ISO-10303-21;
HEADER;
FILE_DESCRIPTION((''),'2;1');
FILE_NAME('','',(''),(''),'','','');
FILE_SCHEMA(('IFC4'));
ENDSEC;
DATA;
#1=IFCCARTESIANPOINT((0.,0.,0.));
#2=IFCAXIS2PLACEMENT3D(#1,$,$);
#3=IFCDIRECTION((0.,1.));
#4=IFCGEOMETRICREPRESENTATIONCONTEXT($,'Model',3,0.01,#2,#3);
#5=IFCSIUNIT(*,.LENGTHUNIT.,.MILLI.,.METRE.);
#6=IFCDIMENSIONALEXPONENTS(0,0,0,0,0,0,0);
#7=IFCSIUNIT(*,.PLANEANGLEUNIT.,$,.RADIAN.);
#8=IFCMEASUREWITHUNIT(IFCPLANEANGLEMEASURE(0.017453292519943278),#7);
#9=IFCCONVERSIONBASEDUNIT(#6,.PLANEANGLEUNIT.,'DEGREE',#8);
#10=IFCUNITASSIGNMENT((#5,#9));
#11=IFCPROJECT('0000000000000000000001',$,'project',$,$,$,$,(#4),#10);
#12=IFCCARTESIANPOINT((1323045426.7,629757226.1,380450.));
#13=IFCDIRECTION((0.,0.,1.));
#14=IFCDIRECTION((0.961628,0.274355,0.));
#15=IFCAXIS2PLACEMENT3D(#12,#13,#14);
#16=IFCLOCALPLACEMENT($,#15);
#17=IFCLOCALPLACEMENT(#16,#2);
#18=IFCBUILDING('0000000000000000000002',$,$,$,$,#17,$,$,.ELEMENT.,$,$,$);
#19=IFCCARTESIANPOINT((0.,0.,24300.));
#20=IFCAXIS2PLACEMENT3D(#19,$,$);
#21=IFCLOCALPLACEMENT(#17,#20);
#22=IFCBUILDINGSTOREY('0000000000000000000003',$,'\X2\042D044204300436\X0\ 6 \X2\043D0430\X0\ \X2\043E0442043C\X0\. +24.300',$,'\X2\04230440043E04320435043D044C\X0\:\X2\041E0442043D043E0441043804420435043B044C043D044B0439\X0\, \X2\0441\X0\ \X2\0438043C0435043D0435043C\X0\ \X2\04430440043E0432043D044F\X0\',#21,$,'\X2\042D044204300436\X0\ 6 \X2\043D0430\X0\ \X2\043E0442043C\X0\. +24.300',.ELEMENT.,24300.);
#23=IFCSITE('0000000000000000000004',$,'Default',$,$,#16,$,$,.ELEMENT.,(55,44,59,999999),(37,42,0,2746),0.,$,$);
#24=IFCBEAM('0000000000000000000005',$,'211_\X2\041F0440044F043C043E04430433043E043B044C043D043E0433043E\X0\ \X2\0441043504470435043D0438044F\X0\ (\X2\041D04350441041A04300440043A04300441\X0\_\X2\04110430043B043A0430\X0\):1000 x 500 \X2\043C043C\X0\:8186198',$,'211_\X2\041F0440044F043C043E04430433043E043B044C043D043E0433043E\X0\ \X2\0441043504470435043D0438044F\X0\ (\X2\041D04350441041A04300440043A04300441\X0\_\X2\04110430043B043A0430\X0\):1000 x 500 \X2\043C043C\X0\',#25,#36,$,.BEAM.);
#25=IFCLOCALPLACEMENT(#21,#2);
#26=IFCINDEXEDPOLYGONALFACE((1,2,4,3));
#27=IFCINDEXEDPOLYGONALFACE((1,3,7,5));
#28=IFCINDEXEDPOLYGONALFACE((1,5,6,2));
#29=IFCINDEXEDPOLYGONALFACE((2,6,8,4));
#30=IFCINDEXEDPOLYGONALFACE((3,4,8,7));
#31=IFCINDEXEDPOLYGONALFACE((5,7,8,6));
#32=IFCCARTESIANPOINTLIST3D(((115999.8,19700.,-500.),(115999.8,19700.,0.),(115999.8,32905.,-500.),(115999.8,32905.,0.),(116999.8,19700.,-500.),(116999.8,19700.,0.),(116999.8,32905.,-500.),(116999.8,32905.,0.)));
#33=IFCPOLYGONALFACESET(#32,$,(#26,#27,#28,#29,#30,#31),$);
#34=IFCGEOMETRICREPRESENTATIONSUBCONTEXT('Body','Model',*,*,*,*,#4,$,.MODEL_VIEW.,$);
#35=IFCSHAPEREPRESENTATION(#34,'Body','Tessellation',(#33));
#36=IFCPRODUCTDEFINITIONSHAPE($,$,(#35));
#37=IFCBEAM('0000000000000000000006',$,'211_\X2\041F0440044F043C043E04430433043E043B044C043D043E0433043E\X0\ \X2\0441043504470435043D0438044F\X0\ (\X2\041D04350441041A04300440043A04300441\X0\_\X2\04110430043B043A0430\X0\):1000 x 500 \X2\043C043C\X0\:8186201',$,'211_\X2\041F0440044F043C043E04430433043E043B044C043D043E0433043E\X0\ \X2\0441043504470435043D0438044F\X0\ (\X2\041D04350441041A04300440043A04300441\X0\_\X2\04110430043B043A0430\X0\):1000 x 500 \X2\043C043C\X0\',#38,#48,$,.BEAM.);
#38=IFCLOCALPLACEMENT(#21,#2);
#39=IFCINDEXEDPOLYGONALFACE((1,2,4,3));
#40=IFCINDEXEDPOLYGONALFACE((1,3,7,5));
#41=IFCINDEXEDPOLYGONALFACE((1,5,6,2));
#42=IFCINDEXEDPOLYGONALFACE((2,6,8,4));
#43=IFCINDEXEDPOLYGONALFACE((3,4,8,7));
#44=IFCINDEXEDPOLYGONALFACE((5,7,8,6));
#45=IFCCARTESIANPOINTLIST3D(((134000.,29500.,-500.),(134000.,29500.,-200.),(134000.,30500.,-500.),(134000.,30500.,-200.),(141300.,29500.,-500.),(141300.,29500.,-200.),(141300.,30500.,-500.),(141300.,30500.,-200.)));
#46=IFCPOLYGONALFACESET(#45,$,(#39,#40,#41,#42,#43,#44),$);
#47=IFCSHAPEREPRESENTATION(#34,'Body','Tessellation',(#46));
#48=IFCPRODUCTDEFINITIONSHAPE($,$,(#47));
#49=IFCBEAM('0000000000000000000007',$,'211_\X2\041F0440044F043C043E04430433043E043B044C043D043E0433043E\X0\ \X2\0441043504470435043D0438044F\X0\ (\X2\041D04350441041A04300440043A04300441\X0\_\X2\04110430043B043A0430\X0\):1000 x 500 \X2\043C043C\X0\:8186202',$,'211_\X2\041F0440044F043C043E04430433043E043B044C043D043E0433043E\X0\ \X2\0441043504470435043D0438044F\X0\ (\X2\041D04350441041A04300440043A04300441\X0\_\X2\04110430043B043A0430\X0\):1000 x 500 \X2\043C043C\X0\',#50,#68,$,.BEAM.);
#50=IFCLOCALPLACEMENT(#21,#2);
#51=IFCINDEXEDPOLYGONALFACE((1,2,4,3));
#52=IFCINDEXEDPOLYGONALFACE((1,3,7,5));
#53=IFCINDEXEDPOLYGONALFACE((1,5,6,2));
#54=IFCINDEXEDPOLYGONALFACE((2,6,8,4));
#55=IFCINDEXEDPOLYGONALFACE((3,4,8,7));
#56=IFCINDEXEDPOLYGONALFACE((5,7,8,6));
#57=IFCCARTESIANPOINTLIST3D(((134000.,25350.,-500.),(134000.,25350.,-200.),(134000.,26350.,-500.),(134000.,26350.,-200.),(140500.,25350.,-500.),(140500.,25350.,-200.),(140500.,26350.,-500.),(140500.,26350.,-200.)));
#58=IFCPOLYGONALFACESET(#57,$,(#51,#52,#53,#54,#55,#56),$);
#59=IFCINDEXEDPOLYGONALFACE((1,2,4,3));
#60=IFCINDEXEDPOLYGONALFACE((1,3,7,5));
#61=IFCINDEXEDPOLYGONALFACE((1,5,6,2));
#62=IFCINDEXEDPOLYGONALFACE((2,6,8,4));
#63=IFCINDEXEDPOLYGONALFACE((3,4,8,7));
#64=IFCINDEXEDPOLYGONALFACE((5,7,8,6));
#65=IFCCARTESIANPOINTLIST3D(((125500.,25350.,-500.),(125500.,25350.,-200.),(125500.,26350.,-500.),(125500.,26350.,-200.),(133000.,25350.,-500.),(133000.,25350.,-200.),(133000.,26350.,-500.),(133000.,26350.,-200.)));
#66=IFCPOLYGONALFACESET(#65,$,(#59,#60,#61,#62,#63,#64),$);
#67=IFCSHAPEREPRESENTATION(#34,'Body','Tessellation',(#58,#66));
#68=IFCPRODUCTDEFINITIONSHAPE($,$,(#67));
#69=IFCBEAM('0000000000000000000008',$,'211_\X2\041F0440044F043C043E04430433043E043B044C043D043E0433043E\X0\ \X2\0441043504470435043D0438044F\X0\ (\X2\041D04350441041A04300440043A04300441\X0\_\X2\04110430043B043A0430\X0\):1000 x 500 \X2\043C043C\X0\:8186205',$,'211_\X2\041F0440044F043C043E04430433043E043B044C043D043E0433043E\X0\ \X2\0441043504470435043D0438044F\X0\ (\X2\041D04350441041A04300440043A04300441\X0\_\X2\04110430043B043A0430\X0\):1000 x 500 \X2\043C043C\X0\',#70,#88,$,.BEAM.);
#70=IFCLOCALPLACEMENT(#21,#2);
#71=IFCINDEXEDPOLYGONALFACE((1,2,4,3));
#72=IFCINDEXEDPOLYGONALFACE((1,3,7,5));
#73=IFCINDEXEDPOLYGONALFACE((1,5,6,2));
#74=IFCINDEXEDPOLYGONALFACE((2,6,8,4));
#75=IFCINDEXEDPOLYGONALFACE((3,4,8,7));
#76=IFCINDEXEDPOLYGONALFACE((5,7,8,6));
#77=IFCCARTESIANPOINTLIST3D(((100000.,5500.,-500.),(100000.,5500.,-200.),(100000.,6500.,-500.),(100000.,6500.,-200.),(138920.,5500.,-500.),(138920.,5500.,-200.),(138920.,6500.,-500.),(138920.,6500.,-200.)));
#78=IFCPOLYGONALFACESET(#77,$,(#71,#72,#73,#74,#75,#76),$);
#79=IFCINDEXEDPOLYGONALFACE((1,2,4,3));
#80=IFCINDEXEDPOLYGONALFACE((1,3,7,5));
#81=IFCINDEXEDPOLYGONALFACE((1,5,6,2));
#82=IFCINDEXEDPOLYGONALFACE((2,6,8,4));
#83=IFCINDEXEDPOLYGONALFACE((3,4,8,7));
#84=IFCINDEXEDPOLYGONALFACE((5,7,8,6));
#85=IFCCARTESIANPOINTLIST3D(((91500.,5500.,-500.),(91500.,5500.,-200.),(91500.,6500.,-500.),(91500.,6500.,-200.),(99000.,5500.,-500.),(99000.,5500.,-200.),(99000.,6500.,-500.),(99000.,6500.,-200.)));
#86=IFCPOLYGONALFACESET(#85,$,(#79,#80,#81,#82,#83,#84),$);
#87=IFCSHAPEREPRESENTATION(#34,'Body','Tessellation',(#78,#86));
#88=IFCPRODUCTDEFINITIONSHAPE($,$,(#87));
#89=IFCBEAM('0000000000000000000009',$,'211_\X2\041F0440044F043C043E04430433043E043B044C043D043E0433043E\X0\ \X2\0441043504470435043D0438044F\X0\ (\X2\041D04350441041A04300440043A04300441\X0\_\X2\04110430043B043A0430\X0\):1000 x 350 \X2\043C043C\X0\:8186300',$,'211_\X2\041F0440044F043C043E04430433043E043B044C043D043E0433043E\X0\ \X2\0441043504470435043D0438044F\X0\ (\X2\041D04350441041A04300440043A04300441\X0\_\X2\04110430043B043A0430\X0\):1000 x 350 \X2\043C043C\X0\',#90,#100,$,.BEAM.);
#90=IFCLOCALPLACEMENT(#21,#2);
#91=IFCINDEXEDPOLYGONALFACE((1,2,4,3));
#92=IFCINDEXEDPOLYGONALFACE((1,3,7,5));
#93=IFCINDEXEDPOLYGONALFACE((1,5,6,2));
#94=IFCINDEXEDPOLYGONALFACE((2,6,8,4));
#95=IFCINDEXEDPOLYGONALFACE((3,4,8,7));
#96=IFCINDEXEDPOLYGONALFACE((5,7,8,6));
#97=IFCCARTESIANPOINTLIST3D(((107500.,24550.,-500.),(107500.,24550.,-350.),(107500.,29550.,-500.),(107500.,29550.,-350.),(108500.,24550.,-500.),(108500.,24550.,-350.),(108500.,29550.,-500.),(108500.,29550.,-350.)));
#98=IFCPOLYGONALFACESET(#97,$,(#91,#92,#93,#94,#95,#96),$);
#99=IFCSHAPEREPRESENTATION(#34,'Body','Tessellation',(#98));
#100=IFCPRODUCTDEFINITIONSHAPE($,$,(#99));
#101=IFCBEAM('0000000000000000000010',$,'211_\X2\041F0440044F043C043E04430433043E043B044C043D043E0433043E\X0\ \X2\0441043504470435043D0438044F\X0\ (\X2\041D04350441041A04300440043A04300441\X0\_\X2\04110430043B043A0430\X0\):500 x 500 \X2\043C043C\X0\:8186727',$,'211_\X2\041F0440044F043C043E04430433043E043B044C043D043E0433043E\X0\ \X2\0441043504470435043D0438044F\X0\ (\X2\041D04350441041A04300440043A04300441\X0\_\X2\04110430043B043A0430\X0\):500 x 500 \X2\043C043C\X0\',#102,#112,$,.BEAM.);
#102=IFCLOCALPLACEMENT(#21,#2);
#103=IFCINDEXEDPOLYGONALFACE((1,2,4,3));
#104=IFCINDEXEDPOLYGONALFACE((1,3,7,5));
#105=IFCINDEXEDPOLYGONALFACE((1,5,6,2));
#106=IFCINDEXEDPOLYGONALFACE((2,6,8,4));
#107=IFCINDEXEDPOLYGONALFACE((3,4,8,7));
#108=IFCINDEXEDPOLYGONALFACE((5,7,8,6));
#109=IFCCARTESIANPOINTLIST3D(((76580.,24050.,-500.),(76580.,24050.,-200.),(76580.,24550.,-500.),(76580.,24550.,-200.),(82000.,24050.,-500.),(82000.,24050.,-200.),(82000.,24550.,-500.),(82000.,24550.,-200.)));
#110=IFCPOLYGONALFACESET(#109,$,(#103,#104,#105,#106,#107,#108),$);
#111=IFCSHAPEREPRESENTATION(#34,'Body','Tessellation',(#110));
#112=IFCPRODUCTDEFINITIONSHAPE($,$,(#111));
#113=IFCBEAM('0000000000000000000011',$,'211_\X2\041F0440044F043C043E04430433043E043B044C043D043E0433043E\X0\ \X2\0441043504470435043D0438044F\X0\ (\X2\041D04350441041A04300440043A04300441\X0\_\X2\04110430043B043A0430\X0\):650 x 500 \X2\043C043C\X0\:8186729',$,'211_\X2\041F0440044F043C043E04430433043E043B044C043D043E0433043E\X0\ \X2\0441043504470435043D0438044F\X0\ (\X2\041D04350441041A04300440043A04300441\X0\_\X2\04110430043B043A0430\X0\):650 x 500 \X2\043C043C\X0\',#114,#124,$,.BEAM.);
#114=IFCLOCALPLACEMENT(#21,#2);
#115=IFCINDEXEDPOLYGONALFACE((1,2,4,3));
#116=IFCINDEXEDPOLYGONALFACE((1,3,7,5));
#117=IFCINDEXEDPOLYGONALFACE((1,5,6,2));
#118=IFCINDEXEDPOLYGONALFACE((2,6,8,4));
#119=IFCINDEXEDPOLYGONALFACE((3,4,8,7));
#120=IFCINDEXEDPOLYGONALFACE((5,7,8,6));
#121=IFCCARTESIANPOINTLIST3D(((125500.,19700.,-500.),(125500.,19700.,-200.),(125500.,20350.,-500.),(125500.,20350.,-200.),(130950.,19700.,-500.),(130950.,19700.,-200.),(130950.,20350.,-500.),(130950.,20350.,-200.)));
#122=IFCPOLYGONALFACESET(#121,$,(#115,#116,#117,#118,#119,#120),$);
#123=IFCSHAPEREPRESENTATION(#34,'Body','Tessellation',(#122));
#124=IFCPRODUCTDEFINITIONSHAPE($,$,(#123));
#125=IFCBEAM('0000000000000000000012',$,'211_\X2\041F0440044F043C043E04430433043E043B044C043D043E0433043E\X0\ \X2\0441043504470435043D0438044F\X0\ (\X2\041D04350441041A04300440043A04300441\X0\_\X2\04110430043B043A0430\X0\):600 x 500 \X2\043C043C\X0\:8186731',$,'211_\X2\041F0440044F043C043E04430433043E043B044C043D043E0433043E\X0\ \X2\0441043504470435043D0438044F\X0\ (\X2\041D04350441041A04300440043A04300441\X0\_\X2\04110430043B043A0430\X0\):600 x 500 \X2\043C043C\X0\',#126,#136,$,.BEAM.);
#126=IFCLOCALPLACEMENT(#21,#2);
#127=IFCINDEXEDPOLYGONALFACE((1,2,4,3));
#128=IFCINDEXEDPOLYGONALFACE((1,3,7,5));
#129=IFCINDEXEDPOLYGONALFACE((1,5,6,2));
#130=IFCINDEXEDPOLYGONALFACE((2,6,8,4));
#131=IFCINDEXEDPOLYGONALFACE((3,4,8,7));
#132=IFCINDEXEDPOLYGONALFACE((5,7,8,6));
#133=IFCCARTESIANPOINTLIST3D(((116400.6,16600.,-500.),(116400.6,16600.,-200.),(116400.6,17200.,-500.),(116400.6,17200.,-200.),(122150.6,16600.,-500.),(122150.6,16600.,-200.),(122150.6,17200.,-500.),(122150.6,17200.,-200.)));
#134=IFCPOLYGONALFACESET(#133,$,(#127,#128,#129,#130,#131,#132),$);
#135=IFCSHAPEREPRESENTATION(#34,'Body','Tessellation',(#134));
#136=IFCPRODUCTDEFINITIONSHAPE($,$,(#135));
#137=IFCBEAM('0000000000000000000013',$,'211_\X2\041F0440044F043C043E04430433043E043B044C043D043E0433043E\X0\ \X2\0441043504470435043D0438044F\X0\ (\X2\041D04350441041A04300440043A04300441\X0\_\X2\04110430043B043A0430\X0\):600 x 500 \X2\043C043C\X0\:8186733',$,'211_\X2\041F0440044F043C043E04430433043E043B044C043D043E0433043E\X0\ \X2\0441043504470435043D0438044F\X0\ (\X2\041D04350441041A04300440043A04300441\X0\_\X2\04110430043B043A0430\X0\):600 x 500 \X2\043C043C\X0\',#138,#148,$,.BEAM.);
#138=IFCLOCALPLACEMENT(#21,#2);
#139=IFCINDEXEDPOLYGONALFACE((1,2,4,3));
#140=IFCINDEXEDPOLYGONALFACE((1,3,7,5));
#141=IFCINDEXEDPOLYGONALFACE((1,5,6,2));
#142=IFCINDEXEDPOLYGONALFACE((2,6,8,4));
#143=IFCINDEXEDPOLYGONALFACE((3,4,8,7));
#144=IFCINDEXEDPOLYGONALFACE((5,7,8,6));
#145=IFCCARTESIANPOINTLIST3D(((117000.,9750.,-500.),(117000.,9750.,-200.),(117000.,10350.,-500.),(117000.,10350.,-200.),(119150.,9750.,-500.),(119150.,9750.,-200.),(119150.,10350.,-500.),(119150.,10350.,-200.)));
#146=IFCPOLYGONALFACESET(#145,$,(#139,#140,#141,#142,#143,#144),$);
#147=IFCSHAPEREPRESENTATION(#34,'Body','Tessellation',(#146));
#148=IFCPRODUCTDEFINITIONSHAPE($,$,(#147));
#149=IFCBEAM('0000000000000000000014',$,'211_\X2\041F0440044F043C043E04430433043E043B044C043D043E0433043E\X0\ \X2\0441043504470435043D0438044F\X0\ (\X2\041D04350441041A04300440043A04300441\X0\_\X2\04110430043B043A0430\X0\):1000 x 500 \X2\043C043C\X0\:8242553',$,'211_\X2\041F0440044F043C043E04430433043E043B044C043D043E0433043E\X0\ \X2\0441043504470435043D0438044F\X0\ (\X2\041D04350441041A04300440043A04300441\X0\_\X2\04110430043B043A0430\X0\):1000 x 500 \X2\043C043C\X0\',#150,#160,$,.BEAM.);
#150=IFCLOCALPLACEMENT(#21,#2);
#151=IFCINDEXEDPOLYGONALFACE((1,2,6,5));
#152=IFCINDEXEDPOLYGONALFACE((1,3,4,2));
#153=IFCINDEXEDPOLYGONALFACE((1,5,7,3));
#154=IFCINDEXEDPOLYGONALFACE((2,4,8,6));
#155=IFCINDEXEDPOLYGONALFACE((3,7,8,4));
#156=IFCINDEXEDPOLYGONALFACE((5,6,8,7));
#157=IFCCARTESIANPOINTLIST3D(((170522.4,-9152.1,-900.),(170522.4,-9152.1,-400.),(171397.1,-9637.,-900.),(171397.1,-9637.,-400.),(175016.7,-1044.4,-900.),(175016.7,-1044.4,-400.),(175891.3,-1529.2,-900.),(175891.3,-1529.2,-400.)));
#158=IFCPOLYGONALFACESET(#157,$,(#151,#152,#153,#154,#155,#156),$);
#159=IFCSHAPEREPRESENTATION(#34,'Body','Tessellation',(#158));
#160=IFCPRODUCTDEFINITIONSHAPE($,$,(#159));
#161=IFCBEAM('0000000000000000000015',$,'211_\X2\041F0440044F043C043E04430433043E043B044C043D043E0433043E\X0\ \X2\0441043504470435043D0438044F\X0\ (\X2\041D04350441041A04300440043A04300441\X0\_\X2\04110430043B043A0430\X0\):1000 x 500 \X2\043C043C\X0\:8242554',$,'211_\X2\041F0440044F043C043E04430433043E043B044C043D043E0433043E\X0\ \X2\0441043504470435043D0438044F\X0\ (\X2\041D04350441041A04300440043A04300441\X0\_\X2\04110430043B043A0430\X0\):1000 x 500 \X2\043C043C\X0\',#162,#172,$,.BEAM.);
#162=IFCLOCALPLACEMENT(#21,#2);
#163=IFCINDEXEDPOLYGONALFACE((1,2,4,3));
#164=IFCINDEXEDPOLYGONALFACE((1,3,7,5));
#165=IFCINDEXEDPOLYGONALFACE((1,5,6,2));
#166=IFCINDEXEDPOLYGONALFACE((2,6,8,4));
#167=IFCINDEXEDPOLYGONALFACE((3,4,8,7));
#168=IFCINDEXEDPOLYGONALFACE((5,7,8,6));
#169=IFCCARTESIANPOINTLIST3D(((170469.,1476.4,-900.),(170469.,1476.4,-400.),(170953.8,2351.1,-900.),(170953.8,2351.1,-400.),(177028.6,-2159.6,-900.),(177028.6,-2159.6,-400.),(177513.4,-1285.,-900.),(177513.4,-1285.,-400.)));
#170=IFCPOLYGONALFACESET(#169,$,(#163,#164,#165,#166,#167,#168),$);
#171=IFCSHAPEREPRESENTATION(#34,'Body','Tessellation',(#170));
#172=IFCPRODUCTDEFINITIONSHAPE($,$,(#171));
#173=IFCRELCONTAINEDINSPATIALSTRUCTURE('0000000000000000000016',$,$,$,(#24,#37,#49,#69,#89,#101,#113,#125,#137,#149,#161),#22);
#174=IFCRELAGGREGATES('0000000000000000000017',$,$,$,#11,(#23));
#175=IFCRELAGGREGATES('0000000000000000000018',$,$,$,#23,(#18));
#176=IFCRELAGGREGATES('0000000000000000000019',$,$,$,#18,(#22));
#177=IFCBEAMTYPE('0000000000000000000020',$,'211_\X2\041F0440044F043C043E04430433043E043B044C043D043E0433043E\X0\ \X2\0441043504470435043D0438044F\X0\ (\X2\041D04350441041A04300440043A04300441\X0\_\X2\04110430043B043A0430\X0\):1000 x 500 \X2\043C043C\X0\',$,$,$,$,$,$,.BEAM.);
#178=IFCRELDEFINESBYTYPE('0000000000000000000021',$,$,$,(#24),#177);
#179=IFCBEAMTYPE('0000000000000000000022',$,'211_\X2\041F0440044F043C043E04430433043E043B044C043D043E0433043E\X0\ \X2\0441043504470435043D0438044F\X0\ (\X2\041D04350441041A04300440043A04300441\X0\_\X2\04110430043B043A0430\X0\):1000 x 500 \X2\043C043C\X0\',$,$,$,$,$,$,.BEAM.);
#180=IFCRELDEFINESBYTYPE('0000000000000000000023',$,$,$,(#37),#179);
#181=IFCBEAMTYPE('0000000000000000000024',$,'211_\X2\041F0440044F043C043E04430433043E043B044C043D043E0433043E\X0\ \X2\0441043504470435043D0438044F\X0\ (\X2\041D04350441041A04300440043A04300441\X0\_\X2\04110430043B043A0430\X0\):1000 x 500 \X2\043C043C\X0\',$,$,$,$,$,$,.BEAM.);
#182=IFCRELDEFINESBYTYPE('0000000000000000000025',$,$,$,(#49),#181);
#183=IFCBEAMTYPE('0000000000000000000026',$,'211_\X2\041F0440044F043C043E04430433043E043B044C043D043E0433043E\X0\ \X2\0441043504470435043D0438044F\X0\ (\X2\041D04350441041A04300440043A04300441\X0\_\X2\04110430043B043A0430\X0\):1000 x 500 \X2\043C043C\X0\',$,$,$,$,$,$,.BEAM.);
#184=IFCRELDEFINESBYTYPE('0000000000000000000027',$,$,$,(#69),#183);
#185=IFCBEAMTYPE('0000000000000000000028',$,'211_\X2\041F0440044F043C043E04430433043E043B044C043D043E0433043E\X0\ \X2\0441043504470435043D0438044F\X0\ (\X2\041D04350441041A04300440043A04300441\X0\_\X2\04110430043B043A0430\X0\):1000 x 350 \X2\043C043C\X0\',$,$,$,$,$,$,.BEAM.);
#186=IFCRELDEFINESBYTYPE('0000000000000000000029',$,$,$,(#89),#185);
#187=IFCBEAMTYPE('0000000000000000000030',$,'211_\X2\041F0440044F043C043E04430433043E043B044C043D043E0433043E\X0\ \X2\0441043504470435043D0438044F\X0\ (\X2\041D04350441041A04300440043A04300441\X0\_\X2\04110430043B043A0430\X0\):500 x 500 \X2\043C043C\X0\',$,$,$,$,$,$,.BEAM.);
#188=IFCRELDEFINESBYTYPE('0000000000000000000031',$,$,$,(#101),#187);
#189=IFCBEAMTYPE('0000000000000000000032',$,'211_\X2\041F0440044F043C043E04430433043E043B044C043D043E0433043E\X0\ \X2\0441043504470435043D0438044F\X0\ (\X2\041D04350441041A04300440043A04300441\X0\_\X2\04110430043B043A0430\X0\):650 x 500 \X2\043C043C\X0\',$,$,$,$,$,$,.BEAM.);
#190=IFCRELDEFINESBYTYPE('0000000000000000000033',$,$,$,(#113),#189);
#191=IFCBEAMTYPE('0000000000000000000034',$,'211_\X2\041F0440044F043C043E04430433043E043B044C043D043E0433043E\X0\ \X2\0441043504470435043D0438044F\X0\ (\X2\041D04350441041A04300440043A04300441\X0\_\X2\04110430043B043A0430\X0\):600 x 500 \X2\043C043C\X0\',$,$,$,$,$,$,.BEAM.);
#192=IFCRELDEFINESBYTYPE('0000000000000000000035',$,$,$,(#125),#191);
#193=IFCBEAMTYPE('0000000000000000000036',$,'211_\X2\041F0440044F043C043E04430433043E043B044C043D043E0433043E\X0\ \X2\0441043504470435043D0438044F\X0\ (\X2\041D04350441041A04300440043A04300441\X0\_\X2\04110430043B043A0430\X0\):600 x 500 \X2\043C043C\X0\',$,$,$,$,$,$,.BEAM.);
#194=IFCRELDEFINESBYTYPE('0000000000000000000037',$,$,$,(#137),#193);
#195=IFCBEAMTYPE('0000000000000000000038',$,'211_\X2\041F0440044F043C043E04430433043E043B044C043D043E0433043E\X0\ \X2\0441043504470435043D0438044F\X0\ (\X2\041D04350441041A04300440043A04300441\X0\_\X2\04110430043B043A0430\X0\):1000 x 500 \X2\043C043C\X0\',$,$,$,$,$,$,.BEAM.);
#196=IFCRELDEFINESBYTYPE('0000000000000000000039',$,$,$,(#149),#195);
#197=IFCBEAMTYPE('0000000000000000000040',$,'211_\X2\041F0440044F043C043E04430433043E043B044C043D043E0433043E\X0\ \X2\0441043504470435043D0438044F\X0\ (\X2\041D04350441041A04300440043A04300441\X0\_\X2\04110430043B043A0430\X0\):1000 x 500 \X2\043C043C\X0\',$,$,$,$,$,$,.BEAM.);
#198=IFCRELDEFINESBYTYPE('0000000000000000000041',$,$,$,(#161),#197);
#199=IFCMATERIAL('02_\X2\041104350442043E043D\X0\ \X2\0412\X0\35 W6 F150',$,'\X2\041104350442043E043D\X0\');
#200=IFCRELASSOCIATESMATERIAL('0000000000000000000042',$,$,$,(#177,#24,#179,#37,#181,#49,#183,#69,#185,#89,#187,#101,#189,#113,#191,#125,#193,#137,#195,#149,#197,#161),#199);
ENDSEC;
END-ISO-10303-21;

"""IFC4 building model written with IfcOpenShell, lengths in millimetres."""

from ifc_helpers import new_model, entity, si_unit, converted_unit, direction, frame, origin, place, context, subcontext, project, spatial, indexed_curve, outline, extrude, source, transform, mapped, material, type_object, type_shapes, element, save


model = new_model("IFC4")

# Units and contexts
model_context = context("Model", 3, precision=0.01, world=origin(), true_north=direction((0.0, 1.0)))
body_context = subcontext(model_context, "Body", "Model", "MODEL_VIEW")
ifc_project = project(units=[si_unit("LENGTHUNIT", "METRE", prefix="MILLI"), converted_unit("PLANEANGLEUNIT", "DEGREE", entity("IfcPlaneAngleMeasure", 0.017453292519943278), si_unit("PLANEANGLEUNIT", "RADIAN"), dimensions=[0, 0, 0, 0, 0, 0, 0])], contexts=[model_context])

# Site, building, storey
site_placement = place(None, frame((1323045426.7, 629757226.1, 380450.0), z_axis=(0.0, 0.0, 1.0), x_axis=(0.961628, 0.274355, 0.0)))
site = spatial("IfcSite", under=ifc_project, at=site_placement, Name="Default", CompositionType="ELEMENT", RefLatitude=(55, 44, 59, 999999), RefLongitude=(37, 42, 0, 2746), RefElevation=0.0)
building_placement = place(site_placement, origin())
building = spatial("IfcBuilding", under=site, at=building_placement, CompositionType="ELEMENT")
storey_placement = place(building_placement, frame((0.0, 0.0, 24300.0)))
storey = spatial("IfcBuildingStorey", under=building, at=storey_placement, Name="Этаж 6 на отм. +24.300", ObjectType="Уровень:Относительный, с именем уровня", LongName="Этаж 6 на отм. +24.300", CompositionType="ELEMENT", Elevation=24300.0)

# Beams
ifc_material_1 = material(Name="02_Бетон В35 W6 F150", Category="Бетон")
beam_type_1 = type_object("IfcBeamType", Name="211_Прямоугольного сечения (НесКаркас_Балка):1000 x 500 мм", PredefinedType="BEAM", material=ifc_material_1)
shared_shape_1 = source(origin(), body_context, "Body", "SweptSolid", [
    extrude(outline(indexed_curve([(-500.0, -250.0), (500.0, -250.0), (500.0, 250.0), (-500.0, 250.0), (-500.0, -250.0)], self_intersect=False)), frame((116499.8, 32905.0, 24050.0), z_axis=(0.0, -1.0, 0.0), x_axis=(-1.0, 0.0, 0.0)), (0.0, 0.0, 1.0), 13205.0),
])
type_shapes(beam_type_1, [shared_shape_1])
beam_1_placement = place(storey_placement, frame((0.0, 0.0, -24300.0)))
element("IfcBeam", 1, at=beam_1_placement, inside=storey, type_object=beam_type_1, material=ifc_material_1, Name="211_Прямоугольного сечения (НесКаркас_Балка):1000 x 500 мм:8186198", ObjectType="211_Прямоугольного сечения (НесКаркас_Балка):1000 x 500 мм", PredefinedType="BEAM", context=body_context, shape_type="MappedRepresentation", body=[
    mapped(shared_shape_1, transform((0.0, 0.0, 0.0), scale=1.0)),
])
beam_type_2 = type_object("IfcBeamType", Name="211_Прямоугольного сечения (НесКаркас_Балка):1000 x 500 мм", PredefinedType="BEAM", material=ifc_material_1)
shared_shape_2 = source(origin(), body_context, "Body", "SweptSolid", [
    extrude(outline(indexed_curve([(-150.0, -500.0), (150.0, -500.0), (150.0, 500.0), (-150.0, 500.0), (-150.0, -500.0)], self_intersect=False)), frame((134000.0, 30000.0, 23950.0), z_axis=(1.0, 0.0, 0.0), x_axis=(0.0, 0.0, -1.0)), (0.0, 0.0, 1.0), 7300.0),
])
type_shapes(beam_type_2, [shared_shape_2])
beam_2_placement = place(storey_placement, frame((0.0, 0.0, -24300.0)))
element("IfcBeam", 2, at=beam_2_placement, inside=storey, type_object=beam_type_2, material=ifc_material_1, Name="211_Прямоугольного сечения (НесКаркас_Балка):1000 x 500 мм:8186201", ObjectType="211_Прямоугольного сечения (НесКаркас_Балка):1000 x 500 мм", PredefinedType="BEAM", context=body_context, shape_type="MappedRepresentation", body=[
    mapped(shared_shape_2, transform((0.0, 0.0, 0.0), scale=1.0)),
])
beam_type_3 = type_object("IfcBeamType", Name="211_Прямоугольного сечения (НесКаркас_Балка):1000 x 500 мм", PredefinedType="BEAM", material=ifc_material_1)
shared_shape_3 = source(origin(), body_context, "Body", "SweptSolid", [
    extrude(outline(indexed_curve([(-150.0, -500.0), (150.0, -500.0), (150.0, 500.0), (-150.0, 500.0), (-150.0, -500.0)], self_intersect=False)), frame((134000.0, 25850.0, 23950.0), z_axis=(1.0, 0.0, 0.0), x_axis=(0.0, 0.0, -1.0)), (0.0, 0.0, 1.0), 6500.0),
    extrude(outline(indexed_curve([(-150.0, -500.0), (150.0, -500.0), (150.0, 500.0), (-150.0, 500.0), (-150.0, -500.0)], self_intersect=False)), frame((125500.0, 25850.0, 23950.0), z_axis=(1.0, 0.0, 0.0), x_axis=(0.0, 0.0, -1.0)), (0.0, 0.0, 1.0), 7500.0),
])
type_shapes(beam_type_3, [shared_shape_3])
beam_3_placement = place(storey_placement, frame((0.0, 0.0, -24300.0)))
element("IfcBeam", 3, at=beam_3_placement, inside=storey, type_object=beam_type_3, material=ifc_material_1, Name="211_Прямоугольного сечения (НесКаркас_Балка):1000 x 500 мм:8186202", ObjectType="211_Прямоугольного сечения (НесКаркас_Балка):1000 x 500 мм", PredefinedType="BEAM", context=body_context, shape_type="MappedRepresentation", body=[
    mapped(shared_shape_3, transform((0.0, 0.0, 0.0), scale=1.0)),
])
beam_type_4 = type_object("IfcBeamType", Name="211_Прямоугольного сечения (НесКаркас_Балка):1000 x 500 мм", PredefinedType="BEAM", material=ifc_material_1)
shared_shape_4 = source(origin(), body_context, "Body", "SweptSolid", [
    extrude(outline(indexed_curve([(-150.0, -500.0), (150.0, -500.0), (150.0, 500.0), (-150.0, 500.0), (-150.0, -500.0)], self_intersect=False)), frame((138920.0, 6000.0, 23950.0), z_axis=(-1.0, 0.0, 0.0), x_axis=(0.0, 0.0, -1.0)), (0.0, 0.0, 1.0), 38920.0),
    extrude(outline(indexed_curve([(-150.0, -500.0), (150.0, -500.0), (150.0, 500.0), (-150.0, 500.0), (-150.0, -500.0)], self_intersect=False)), frame((99000.0, 6000.0, 23950.0), z_axis=(-1.0, 0.0, 0.0), x_axis=(0.0, 0.0, -1.0)), (0.0, 0.0, 1.0), 7500.0),
])
type_shapes(beam_type_4, [shared_shape_4])
beam_4_placement = place(storey_placement, frame((0.0, 0.0, -24300.0)))
element("IfcBeam", 4, at=beam_4_placement, inside=storey, type_object=beam_type_4, material=ifc_material_1, Name="211_Прямоугольного сечения (НесКаркас_Балка):1000 x 500 мм:8186205", ObjectType="211_Прямоугольного сечения (НесКаркас_Балка):1000 x 500 мм", PredefinedType="BEAM", context=body_context, shape_type="MappedRepresentation", body=[
    mapped(shared_shape_4, transform((0.0, 0.0, 0.0), scale=1.0)),
])
beam_type_5 = type_object("IfcBeamType", Name="211_Прямоугольного сечения (НесКаркас_Балка):1000 x 350 мм", PredefinedType="BEAM", material=ifc_material_1)
shared_shape_5 = source(origin(), body_context, "Body", "SweptSolid", [
    extrude(outline(indexed_curve([(-500.0, -75.0), (500.0, -75.0), (500.0, 75.0), (-500.0, 75.0), (-500.0, -75.0)], self_intersect=False)), frame((108000.0, 29550.0, 23875.0), z_axis=(0.0, -1.0, 0.0), x_axis=(-1.0, 0.0, 0.0)), (0.0, 0.0, 1.0), 5000.0),
])
type_shapes(beam_type_5, [shared_shape_5])
beam_5_placement = place(storey_placement, frame((0.0, 0.0, -24300.0)))
element("IfcBeam", 5, at=beam_5_placement, inside=storey, type_object=beam_type_5, material=ifc_material_1, Name="211_Прямоугольного сечения (НесКаркас_Балка):1000 x 350 мм:8186300", ObjectType="211_Прямоугольного сечения (НесКаркас_Балка):1000 x 350 мм", PredefinedType="BEAM", context=body_context, shape_type="MappedRepresentation", body=[
    mapped(shared_shape_5, transform((0.0, 0.0, 0.0), scale=1.0)),
])
beam_type_6 = type_object("IfcBeamType", Name="211_Прямоугольного сечения (НесКаркас_Балка):500 x 500 мм", PredefinedType="BEAM", material=ifc_material_1)
shared_shape_6 = source(origin(), body_context, "Body", "SweptSolid", [
    extrude(outline(indexed_curve([(-150.0, -250.0), (150.0, -250.0), (150.0, 250.0), (-150.0, 250.0), (-150.0, -250.0)], self_intersect=False)), frame((82000.0, 24300.0, 23950.0), z_axis=(-1.0, 0.0, 0.0), x_axis=(0.0, 0.0, -1.0)), (0.0, 0.0, 1.0), 5420.0),
])
type_shapes(beam_type_6, [shared_shape_6])
beam_6_placement = place(storey_placement, frame((0.0, 0.0, -24300.0)))
element("IfcBeam", 6, at=beam_6_placement, inside=storey, type_object=beam_type_6, material=ifc_material_1, Name="211_Прямоугольного сечения (НесКаркас_Балка):500 x 500 мм:8186727", ObjectType="211_Прямоугольного сечения (НесКаркас_Балка):500 x 500 мм", PredefinedType="BEAM", context=body_context, shape_type="MappedRepresentation", body=[
    mapped(shared_shape_6, transform((0.0, 0.0, 0.0), scale=1.0)),
])
beam_type_7 = type_object("IfcBeamType", Name="211_Прямоугольного сечения (НесКаркас_Балка):650 x 500 мм", PredefinedType="BEAM", material=ifc_material_1)
shared_shape_7 = source(origin(), body_context, "Body", "SweptSolid", [
    extrude(outline(indexed_curve([(-150.0, -325.0), (150.0, -325.0), (150.0, 325.0), (-150.0, 325.0), (-150.0, -325.0)], self_intersect=False)), frame((130950.0, 20025.0, 23950.0), z_axis=(-1.0, 0.0, 0.0), x_axis=(0.0, 0.0, -1.0)), (0.0, 0.0, 1.0), 5450.0),
])
type_shapes(beam_type_7, [shared_shape_7])
beam_7_placement = place(storey_placement, frame((0.0, 0.0, -24300.0)))
element("IfcBeam", 7, at=beam_7_placement, inside=storey, type_object=beam_type_7, material=ifc_material_1, Name="211_Прямоугольного сечения (НесКаркас_Балка):650 x 500 мм:8186729", ObjectType="211_Прямоугольного сечения (НесКаркас_Балка):650 x 500 мм", PredefinedType="BEAM", context=body_context, shape_type="MappedRepresentation", body=[
    mapped(shared_shape_7, transform((0.0, 0.0, 0.0), scale=1.0)),
])
beam_type_8 = type_object("IfcBeamType", Name="211_Прямоугольного сечения (НесКаркас_Балка):600 x 500 мм", PredefinedType="BEAM", material=ifc_material_1)
shared_shape_8 = source(origin(), body_context, "Body", "SweptSolid", [
    extrude(outline(indexed_curve([(-150.0, -300.0), (150.0, -300.0), (150.0, 300.0), (-150.0, 300.0), (-150.0, -300.0)], self_intersect=False)), frame((122150.6, 16900.0, 23950.0), z_axis=(-1.0, 0.0, 0.0), x_axis=(0.0, 0.0, -1.0)), (0.0, 0.0, 1.0), 5750.0),
])
type_shapes(beam_type_8, [shared_shape_8])
beam_8_placement = place(storey_placement, frame((0.0, 0.0, -24300.0)))
element("IfcBeam", 8, at=beam_8_placement, inside=storey, type_object=beam_type_8, material=ifc_material_1, Name="211_Прямоугольного сечения (НесКаркас_Балка):600 x 500 мм:8186731", ObjectType="211_Прямоугольного сечения (НесКаркас_Балка):600 x 500 мм", PredefinedType="BEAM", context=body_context, shape_type="MappedRepresentation", body=[
    mapped(shared_shape_8, transform((0.0, 0.0, 0.0), scale=1.0)),
])
beam_type_9 = type_object("IfcBeamType", Name="211_Прямоугольного сечения (НесКаркас_Балка):600 x 500 мм", PredefinedType="BEAM", material=ifc_material_1)
shared_shape_9 = source(origin(), body_context, "Body", "SweptSolid", [
    extrude(outline(indexed_curve([(-150.0, -300.0), (150.0, -300.0), (150.0, 300.0), (-150.0, 300.0), (-150.0, -300.0)], self_intersect=False)), frame((119150.0, 10050.0, 23950.0), z_axis=(-1.0, 0.0, 0.0), x_axis=(0.0, 0.0, -1.0)), (0.0, 0.0, 1.0), 2150.0),
])
type_shapes(beam_type_9, [shared_shape_9])
beam_9_placement = place(storey_placement, frame((0.0, 0.0, -24300.0)))
element("IfcBeam", 9, at=beam_9_placement, inside=storey, type_object=beam_type_9, material=ifc_material_1, Name="211_Прямоугольного сечения (НесКаркас_Балка):600 x 500 мм:8186733", ObjectType="211_Прямоугольного сечения (НесКаркас_Балка):600 x 500 мм", PredefinedType="BEAM", context=body_context, shape_type="MappedRepresentation", body=[
    mapped(shared_shape_9, transform((0.0, 0.0, 0.0), scale=1.0)),
])
beam_type_10 = type_object("IfcBeamType", Name="211_Прямоугольного сечения (НесКаркас_Балка):1000 x 500 мм", PredefinedType="BEAM", material=ifc_material_1)
shared_shape_10 = source(origin(), body_context, "Body", "SweptSolid", [
    extrude(outline(indexed_curve([(-250.0, -500.0), (250.0, -500.0), (250.0, 500.0), (-250.0, 500.0), (-250.0, -500.0)], self_intersect=False)), frame((175454.0, -1286.8, 23650.0), z_axis=(-0.484811, -0.874619, 0.0), x_axis=(0.0, 0.0, -1.0)), (0.0, 0.0, 1.0), 9270.0),
])
type_shapes(beam_type_10, [shared_shape_10])
beam_10_placement = place(storey_placement, frame((0.0, 0.0, -24300.0)))
element("IfcBeam", 10, at=beam_10_placement, inside=storey, type_object=beam_type_10, material=ifc_material_1, Name="211_Прямоугольного сечения (НесКаркас_Балка):1000 x 500 мм:8242553", ObjectType="211_Прямоугольного сечения (НесКаркас_Балка):1000 x 500 мм", PredefinedType="BEAM", context=body_context, shape_type="MappedRepresentation", body=[
    mapped(shared_shape_10, transform((0.0, 0.0, 0.0), scale=1.0)),
])
beam_type_11 = type_object("IfcBeamType", Name="211_Прямоугольного сечения (НесКаркас_Балка):1000 x 500 мм", PredefinedType="BEAM", material=ifc_material_1)
shared_shape_11 = source(origin(), body_context, "Body", "SweptSolid", [
    extrude(outline(indexed_curve([(-250.0, -500.0), (250.0, -500.0), (250.0, 500.0), (-250.0, 500.0), (-250.0, -500.0)], self_intersect=False)), frame((170711.4, 1913.8, 23650.0), z_axis=(0.874619, -0.48481, 0.0), x_axis=(0.0, 0.0, -1.0)), (0.0, 0.0, 1.0), 7500.0),
])
type_shapes(beam_type_11, [shared_shape_11])
beam_11_placement = place(storey_placement, frame((0.0, 0.0, -24300.0)))
element("IfcBeam", 11, at=beam_11_placement, inside=storey, type_object=beam_type_11, material=ifc_material_1, Name="211_Прямоугольного сечения (НесКаркас_Балка):1000 x 500 мм:8242554", ObjectType="211_Прямоугольного сечения (НесКаркас_Балка):1000 x 500 мм", PredefinedType="BEAM", context=body_context, shape_type="MappedRepresentation", body=[
    mapped(shared_shape_11, transform((0.0, 0.0, 0.0), scale=1.0)),
])

save(model, "model.ifc")
